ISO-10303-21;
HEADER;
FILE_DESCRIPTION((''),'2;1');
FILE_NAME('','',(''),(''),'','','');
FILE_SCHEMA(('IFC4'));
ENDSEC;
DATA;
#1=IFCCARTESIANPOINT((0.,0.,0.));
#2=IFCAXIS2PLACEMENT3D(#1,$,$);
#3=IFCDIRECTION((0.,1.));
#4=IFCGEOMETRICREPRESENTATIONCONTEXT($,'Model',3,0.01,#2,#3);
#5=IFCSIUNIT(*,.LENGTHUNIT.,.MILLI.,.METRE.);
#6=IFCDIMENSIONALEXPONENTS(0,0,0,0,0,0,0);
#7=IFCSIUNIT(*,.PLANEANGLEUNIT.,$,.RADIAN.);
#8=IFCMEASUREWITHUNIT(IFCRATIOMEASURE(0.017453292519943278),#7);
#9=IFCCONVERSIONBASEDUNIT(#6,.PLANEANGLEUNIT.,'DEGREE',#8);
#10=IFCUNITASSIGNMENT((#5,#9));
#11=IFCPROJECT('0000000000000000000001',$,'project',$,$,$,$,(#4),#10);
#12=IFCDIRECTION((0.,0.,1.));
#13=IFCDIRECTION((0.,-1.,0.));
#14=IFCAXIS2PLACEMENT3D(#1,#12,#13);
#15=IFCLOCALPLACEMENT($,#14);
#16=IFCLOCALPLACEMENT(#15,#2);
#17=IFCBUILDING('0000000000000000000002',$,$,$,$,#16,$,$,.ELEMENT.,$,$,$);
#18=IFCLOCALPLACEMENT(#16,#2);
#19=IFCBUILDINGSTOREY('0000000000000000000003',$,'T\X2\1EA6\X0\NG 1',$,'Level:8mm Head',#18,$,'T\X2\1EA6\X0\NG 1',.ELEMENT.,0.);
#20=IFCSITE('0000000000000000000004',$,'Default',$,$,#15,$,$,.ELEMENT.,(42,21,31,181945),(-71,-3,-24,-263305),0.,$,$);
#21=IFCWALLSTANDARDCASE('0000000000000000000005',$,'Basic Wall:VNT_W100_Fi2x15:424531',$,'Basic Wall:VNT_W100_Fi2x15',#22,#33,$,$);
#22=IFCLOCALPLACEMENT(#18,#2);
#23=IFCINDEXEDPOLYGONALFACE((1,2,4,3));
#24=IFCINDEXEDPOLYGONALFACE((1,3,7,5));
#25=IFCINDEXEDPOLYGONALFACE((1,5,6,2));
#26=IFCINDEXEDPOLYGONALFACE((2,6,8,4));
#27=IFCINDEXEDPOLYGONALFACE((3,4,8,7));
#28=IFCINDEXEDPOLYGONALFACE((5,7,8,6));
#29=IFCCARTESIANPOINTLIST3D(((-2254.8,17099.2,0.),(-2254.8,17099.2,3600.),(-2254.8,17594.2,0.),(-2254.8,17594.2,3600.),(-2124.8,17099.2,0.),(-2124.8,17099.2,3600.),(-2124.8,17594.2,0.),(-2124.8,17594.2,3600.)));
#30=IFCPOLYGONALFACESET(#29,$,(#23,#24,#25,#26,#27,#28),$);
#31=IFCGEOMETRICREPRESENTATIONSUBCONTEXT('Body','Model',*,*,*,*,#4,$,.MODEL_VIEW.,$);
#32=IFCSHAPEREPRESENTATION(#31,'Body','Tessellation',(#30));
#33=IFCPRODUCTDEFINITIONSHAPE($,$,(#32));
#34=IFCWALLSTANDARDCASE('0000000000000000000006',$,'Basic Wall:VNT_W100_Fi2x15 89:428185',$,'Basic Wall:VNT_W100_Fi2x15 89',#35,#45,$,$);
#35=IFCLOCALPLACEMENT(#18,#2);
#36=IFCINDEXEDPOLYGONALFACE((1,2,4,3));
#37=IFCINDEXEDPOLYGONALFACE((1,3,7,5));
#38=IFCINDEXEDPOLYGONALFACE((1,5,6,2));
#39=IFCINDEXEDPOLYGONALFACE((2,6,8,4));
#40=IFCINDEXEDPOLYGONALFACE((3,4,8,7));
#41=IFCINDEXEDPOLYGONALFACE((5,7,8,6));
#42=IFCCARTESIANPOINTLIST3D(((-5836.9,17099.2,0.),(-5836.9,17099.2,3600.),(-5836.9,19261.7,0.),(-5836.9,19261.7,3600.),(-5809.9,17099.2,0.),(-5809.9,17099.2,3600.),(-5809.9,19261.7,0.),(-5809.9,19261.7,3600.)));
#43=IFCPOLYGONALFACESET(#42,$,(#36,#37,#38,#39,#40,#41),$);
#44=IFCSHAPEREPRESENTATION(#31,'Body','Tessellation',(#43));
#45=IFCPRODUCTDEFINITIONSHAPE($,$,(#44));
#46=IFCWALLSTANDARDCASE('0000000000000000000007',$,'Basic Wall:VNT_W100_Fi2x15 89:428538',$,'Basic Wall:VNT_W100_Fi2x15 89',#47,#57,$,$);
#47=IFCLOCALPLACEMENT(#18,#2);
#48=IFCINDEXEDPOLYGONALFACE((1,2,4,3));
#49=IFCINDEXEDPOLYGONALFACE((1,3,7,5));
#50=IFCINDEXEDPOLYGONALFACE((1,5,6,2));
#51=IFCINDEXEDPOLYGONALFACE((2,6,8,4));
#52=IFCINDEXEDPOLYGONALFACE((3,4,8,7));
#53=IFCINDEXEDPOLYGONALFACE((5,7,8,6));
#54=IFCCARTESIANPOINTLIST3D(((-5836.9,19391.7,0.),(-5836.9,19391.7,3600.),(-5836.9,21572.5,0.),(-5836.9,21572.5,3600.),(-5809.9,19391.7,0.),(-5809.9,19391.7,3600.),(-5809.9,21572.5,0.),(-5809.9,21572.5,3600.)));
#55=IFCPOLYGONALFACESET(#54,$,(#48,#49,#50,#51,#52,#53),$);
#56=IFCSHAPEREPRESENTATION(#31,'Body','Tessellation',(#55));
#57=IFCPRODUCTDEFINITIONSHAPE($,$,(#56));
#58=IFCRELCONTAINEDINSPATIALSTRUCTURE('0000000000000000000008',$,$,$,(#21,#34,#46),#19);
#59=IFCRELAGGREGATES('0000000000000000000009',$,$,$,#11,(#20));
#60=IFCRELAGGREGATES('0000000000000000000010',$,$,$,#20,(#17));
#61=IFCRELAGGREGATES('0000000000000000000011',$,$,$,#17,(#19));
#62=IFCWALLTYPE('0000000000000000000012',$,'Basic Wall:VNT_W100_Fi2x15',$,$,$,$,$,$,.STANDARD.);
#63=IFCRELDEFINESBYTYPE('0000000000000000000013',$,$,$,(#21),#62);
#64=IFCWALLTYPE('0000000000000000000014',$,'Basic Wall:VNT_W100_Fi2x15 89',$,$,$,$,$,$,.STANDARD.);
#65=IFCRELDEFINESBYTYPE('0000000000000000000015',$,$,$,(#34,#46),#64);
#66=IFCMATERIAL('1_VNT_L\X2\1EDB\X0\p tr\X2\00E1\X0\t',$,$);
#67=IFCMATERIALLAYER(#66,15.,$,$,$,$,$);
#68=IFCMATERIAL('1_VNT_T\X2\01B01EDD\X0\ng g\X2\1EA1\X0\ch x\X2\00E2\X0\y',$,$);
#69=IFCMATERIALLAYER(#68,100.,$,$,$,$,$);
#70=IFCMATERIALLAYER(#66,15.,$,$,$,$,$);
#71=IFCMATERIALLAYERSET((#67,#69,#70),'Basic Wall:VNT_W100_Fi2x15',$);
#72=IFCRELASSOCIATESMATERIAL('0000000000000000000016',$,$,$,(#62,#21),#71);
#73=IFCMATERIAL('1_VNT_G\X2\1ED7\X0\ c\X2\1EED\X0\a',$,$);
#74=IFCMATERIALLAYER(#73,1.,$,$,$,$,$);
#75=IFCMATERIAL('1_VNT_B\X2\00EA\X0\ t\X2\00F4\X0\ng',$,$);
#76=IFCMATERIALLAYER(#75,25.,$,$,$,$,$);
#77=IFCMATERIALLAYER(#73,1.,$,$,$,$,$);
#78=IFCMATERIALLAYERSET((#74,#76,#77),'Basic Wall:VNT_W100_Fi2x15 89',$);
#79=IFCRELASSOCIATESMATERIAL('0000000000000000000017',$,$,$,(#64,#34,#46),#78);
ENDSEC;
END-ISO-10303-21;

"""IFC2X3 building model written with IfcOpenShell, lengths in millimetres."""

from ifc_helpers import new_model, entity, si_unit, converted_unit, direction, frame, frame_2d, origin, place, context, subcontext, project, spatial, rectangle, extrude, material, layer, layer_set, layer_usage, type_object, element, save


model = new_model("IFC2X3")

# Units and contexts
model_context = context("Model", 3, precision=0.01, world=origin(), true_north=direction((0.0, 1.0)))
body_context = subcontext(model_context, "Body", "Model", "MODEL_VIEW")
ifc_project = project(units=[si_unit("LENGTHUNIT", "METRE", prefix="MILLI"), converted_unit("PLANEANGLEUNIT", "DEGREE", entity("IfcRatioMeasure", 0.017453292519943278), si_unit("PLANEANGLEUNIT", "RADIAN"), dimensions=[0, 0, 0, 0, 0, 0, 0])], contexts=[model_context])

# Site, building, storey
site_placement = place(None, frame((0.0, 0.0, 0.0), z_axis=(0.0, 0.0, 1.0), x_axis=(0.0, -1.0, 0.0)))
site = spatial("IfcSite", under=ifc_project, at=site_placement, Name="Default", CompositionType="ELEMENT", RefLatitude=(42, 21, 31, 181945), RefLongitude=(-71, -3, -24, -263305), RefElevation=0.0)
building_placement = place(site_placement, origin())
building = spatial("IfcBuilding", under=site, at=building_placement, CompositionType="ELEMENT")
storey_placement = place(building_placement, origin())
storey = spatial("IfcBuildingStorey", under=building, at=storey_placement, Name="TẦNG 1", ObjectType="Level:8mm Head", LongName="TẦNG 1", CompositionType="ELEMENT", Elevation=0.0)

# Shared definitions
ifc_material_1 = material(Name="1_VNT_Lớp trát")
ifc_material_2 = material(Name="1_VNT_Tường gạch xây")

# Shared definitions
ifc_layer_1 = layer(ifc_material_1, 15.0)
ifc_layer_2 = layer(ifc_material_2, 100.0)
ifc_layer_3 = layer(ifc_material_1, 15.0)
ifc_layer_set_1 = layer_set([ifc_layer_1, ifc_layer_2, ifc_layer_3], Name="Basic Wall:VNT_W100_Fi2x15")
ifc_layer_usage_1 = layer_usage(ifc_layer_set_1, "AXIS2", "NEGATIVE", 65.0)
wall_type_1 = type_object("IfcWallType", Name="Basic Wall:VNT_W100_Fi2x15", PredefinedType="STANDARD", material=ifc_layer_set_1)

# Walls
wall_1_placement = place(storey_placement, frame((-2189.8, 17594.2, 0.0), z_axis=(0.0, 0.0, 1.0), x_axis=(0.0, -1.0, 0.0)))
element("IfcWallStandardCase", 1, at=wall_1_placement, inside=storey, type_object=wall_type_1, material=ifc_layer_usage_1, Name="Basic Wall:VNT_W100_Fi2x15:424531", ObjectType="Basic Wall:VNT_W100_Fi2x15", context=body_context, shape_type="SweptSolid", body=[
    extrude(rectangle(XDim=495.0, YDim=130.0, at=frame_2d((247.5, 0.0), x_axis=(-1.0, 0.0))), origin(), (0.0, 0.0, 1.0), 3600.0),
])
ifc_material_3 = material(Name="1_VNT_Gỗ cửa")
ifc_layer_4 = layer(ifc_material_3, 1.0)
ifc_material_4 = material(Name="1_VNT_Bê tông")
ifc_layer_5 = layer(ifc_material_4, 25.0)
ifc_layer_6 = layer(ifc_material_3, 1.0)
ifc_layer_set_2 = layer_set([ifc_layer_4, ifc_layer_5, ifc_layer_6], Name="Basic Wall:VNT_W100_Fi2x15 89")
ifc_layer_usage_2 = layer_usage(ifc_layer_set_2, "AXIS2", "NEGATIVE", 13.5)
wall_type_2 = type_object("IfcWallType", Name="Basic Wall:VNT_W100_Fi2x15 89", PredefinedType="STANDARD", material=ifc_layer_set_2)
wall_2_placement = place(storey_placement, frame((-5823.4, 17099.2, 0.0), z_axis=(0.0, 0.0, 1.0), x_axis=(0.0, 1.0, 0.0)))
element("IfcWallStandardCase", 2, at=wall_2_placement, inside=storey, type_object=wall_type_2, material=ifc_layer_usage_2, Name="Basic Wall:VNT_W100_Fi2x15 89:428185", ObjectType="Basic Wall:VNT_W100_Fi2x15 89", context=body_context, shape_type="SweptSolid", body=[
    extrude(rectangle(XDim=2162.5, YDim=27.0, at=frame_2d((1081.2, 0.0), x_axis=(-1.0, 0.0))), origin(), (0.0, 0.0, 1.0), 3600.0),
])
wall_3_placement = place(storey_placement, frame((-5823.4, 19391.7, 0.0), z_axis=(0.0, 0.0, 1.0), x_axis=(0.0, 1.0, 0.0)))
element("IfcWallStandardCase", 3, at=wall_3_placement, inside=storey, type_object=wall_type_2, material=ifc_layer_usage_2, Name="Basic Wall:VNT_W100_Fi2x15 89:428538", ObjectType="Basic Wall:VNT_W100_Fi2x15 89", context=body_context, shape_type="SweptSolid", body=[
    extrude(rectangle(XDim=2180.8, YDim=27.0, at=frame_2d((1090.4, 0.0), x_axis=(-1.0, 0.0))), origin(), (0.0, 0.0, 1.0), 3600.0),
])

save(model, "model.ifc")
